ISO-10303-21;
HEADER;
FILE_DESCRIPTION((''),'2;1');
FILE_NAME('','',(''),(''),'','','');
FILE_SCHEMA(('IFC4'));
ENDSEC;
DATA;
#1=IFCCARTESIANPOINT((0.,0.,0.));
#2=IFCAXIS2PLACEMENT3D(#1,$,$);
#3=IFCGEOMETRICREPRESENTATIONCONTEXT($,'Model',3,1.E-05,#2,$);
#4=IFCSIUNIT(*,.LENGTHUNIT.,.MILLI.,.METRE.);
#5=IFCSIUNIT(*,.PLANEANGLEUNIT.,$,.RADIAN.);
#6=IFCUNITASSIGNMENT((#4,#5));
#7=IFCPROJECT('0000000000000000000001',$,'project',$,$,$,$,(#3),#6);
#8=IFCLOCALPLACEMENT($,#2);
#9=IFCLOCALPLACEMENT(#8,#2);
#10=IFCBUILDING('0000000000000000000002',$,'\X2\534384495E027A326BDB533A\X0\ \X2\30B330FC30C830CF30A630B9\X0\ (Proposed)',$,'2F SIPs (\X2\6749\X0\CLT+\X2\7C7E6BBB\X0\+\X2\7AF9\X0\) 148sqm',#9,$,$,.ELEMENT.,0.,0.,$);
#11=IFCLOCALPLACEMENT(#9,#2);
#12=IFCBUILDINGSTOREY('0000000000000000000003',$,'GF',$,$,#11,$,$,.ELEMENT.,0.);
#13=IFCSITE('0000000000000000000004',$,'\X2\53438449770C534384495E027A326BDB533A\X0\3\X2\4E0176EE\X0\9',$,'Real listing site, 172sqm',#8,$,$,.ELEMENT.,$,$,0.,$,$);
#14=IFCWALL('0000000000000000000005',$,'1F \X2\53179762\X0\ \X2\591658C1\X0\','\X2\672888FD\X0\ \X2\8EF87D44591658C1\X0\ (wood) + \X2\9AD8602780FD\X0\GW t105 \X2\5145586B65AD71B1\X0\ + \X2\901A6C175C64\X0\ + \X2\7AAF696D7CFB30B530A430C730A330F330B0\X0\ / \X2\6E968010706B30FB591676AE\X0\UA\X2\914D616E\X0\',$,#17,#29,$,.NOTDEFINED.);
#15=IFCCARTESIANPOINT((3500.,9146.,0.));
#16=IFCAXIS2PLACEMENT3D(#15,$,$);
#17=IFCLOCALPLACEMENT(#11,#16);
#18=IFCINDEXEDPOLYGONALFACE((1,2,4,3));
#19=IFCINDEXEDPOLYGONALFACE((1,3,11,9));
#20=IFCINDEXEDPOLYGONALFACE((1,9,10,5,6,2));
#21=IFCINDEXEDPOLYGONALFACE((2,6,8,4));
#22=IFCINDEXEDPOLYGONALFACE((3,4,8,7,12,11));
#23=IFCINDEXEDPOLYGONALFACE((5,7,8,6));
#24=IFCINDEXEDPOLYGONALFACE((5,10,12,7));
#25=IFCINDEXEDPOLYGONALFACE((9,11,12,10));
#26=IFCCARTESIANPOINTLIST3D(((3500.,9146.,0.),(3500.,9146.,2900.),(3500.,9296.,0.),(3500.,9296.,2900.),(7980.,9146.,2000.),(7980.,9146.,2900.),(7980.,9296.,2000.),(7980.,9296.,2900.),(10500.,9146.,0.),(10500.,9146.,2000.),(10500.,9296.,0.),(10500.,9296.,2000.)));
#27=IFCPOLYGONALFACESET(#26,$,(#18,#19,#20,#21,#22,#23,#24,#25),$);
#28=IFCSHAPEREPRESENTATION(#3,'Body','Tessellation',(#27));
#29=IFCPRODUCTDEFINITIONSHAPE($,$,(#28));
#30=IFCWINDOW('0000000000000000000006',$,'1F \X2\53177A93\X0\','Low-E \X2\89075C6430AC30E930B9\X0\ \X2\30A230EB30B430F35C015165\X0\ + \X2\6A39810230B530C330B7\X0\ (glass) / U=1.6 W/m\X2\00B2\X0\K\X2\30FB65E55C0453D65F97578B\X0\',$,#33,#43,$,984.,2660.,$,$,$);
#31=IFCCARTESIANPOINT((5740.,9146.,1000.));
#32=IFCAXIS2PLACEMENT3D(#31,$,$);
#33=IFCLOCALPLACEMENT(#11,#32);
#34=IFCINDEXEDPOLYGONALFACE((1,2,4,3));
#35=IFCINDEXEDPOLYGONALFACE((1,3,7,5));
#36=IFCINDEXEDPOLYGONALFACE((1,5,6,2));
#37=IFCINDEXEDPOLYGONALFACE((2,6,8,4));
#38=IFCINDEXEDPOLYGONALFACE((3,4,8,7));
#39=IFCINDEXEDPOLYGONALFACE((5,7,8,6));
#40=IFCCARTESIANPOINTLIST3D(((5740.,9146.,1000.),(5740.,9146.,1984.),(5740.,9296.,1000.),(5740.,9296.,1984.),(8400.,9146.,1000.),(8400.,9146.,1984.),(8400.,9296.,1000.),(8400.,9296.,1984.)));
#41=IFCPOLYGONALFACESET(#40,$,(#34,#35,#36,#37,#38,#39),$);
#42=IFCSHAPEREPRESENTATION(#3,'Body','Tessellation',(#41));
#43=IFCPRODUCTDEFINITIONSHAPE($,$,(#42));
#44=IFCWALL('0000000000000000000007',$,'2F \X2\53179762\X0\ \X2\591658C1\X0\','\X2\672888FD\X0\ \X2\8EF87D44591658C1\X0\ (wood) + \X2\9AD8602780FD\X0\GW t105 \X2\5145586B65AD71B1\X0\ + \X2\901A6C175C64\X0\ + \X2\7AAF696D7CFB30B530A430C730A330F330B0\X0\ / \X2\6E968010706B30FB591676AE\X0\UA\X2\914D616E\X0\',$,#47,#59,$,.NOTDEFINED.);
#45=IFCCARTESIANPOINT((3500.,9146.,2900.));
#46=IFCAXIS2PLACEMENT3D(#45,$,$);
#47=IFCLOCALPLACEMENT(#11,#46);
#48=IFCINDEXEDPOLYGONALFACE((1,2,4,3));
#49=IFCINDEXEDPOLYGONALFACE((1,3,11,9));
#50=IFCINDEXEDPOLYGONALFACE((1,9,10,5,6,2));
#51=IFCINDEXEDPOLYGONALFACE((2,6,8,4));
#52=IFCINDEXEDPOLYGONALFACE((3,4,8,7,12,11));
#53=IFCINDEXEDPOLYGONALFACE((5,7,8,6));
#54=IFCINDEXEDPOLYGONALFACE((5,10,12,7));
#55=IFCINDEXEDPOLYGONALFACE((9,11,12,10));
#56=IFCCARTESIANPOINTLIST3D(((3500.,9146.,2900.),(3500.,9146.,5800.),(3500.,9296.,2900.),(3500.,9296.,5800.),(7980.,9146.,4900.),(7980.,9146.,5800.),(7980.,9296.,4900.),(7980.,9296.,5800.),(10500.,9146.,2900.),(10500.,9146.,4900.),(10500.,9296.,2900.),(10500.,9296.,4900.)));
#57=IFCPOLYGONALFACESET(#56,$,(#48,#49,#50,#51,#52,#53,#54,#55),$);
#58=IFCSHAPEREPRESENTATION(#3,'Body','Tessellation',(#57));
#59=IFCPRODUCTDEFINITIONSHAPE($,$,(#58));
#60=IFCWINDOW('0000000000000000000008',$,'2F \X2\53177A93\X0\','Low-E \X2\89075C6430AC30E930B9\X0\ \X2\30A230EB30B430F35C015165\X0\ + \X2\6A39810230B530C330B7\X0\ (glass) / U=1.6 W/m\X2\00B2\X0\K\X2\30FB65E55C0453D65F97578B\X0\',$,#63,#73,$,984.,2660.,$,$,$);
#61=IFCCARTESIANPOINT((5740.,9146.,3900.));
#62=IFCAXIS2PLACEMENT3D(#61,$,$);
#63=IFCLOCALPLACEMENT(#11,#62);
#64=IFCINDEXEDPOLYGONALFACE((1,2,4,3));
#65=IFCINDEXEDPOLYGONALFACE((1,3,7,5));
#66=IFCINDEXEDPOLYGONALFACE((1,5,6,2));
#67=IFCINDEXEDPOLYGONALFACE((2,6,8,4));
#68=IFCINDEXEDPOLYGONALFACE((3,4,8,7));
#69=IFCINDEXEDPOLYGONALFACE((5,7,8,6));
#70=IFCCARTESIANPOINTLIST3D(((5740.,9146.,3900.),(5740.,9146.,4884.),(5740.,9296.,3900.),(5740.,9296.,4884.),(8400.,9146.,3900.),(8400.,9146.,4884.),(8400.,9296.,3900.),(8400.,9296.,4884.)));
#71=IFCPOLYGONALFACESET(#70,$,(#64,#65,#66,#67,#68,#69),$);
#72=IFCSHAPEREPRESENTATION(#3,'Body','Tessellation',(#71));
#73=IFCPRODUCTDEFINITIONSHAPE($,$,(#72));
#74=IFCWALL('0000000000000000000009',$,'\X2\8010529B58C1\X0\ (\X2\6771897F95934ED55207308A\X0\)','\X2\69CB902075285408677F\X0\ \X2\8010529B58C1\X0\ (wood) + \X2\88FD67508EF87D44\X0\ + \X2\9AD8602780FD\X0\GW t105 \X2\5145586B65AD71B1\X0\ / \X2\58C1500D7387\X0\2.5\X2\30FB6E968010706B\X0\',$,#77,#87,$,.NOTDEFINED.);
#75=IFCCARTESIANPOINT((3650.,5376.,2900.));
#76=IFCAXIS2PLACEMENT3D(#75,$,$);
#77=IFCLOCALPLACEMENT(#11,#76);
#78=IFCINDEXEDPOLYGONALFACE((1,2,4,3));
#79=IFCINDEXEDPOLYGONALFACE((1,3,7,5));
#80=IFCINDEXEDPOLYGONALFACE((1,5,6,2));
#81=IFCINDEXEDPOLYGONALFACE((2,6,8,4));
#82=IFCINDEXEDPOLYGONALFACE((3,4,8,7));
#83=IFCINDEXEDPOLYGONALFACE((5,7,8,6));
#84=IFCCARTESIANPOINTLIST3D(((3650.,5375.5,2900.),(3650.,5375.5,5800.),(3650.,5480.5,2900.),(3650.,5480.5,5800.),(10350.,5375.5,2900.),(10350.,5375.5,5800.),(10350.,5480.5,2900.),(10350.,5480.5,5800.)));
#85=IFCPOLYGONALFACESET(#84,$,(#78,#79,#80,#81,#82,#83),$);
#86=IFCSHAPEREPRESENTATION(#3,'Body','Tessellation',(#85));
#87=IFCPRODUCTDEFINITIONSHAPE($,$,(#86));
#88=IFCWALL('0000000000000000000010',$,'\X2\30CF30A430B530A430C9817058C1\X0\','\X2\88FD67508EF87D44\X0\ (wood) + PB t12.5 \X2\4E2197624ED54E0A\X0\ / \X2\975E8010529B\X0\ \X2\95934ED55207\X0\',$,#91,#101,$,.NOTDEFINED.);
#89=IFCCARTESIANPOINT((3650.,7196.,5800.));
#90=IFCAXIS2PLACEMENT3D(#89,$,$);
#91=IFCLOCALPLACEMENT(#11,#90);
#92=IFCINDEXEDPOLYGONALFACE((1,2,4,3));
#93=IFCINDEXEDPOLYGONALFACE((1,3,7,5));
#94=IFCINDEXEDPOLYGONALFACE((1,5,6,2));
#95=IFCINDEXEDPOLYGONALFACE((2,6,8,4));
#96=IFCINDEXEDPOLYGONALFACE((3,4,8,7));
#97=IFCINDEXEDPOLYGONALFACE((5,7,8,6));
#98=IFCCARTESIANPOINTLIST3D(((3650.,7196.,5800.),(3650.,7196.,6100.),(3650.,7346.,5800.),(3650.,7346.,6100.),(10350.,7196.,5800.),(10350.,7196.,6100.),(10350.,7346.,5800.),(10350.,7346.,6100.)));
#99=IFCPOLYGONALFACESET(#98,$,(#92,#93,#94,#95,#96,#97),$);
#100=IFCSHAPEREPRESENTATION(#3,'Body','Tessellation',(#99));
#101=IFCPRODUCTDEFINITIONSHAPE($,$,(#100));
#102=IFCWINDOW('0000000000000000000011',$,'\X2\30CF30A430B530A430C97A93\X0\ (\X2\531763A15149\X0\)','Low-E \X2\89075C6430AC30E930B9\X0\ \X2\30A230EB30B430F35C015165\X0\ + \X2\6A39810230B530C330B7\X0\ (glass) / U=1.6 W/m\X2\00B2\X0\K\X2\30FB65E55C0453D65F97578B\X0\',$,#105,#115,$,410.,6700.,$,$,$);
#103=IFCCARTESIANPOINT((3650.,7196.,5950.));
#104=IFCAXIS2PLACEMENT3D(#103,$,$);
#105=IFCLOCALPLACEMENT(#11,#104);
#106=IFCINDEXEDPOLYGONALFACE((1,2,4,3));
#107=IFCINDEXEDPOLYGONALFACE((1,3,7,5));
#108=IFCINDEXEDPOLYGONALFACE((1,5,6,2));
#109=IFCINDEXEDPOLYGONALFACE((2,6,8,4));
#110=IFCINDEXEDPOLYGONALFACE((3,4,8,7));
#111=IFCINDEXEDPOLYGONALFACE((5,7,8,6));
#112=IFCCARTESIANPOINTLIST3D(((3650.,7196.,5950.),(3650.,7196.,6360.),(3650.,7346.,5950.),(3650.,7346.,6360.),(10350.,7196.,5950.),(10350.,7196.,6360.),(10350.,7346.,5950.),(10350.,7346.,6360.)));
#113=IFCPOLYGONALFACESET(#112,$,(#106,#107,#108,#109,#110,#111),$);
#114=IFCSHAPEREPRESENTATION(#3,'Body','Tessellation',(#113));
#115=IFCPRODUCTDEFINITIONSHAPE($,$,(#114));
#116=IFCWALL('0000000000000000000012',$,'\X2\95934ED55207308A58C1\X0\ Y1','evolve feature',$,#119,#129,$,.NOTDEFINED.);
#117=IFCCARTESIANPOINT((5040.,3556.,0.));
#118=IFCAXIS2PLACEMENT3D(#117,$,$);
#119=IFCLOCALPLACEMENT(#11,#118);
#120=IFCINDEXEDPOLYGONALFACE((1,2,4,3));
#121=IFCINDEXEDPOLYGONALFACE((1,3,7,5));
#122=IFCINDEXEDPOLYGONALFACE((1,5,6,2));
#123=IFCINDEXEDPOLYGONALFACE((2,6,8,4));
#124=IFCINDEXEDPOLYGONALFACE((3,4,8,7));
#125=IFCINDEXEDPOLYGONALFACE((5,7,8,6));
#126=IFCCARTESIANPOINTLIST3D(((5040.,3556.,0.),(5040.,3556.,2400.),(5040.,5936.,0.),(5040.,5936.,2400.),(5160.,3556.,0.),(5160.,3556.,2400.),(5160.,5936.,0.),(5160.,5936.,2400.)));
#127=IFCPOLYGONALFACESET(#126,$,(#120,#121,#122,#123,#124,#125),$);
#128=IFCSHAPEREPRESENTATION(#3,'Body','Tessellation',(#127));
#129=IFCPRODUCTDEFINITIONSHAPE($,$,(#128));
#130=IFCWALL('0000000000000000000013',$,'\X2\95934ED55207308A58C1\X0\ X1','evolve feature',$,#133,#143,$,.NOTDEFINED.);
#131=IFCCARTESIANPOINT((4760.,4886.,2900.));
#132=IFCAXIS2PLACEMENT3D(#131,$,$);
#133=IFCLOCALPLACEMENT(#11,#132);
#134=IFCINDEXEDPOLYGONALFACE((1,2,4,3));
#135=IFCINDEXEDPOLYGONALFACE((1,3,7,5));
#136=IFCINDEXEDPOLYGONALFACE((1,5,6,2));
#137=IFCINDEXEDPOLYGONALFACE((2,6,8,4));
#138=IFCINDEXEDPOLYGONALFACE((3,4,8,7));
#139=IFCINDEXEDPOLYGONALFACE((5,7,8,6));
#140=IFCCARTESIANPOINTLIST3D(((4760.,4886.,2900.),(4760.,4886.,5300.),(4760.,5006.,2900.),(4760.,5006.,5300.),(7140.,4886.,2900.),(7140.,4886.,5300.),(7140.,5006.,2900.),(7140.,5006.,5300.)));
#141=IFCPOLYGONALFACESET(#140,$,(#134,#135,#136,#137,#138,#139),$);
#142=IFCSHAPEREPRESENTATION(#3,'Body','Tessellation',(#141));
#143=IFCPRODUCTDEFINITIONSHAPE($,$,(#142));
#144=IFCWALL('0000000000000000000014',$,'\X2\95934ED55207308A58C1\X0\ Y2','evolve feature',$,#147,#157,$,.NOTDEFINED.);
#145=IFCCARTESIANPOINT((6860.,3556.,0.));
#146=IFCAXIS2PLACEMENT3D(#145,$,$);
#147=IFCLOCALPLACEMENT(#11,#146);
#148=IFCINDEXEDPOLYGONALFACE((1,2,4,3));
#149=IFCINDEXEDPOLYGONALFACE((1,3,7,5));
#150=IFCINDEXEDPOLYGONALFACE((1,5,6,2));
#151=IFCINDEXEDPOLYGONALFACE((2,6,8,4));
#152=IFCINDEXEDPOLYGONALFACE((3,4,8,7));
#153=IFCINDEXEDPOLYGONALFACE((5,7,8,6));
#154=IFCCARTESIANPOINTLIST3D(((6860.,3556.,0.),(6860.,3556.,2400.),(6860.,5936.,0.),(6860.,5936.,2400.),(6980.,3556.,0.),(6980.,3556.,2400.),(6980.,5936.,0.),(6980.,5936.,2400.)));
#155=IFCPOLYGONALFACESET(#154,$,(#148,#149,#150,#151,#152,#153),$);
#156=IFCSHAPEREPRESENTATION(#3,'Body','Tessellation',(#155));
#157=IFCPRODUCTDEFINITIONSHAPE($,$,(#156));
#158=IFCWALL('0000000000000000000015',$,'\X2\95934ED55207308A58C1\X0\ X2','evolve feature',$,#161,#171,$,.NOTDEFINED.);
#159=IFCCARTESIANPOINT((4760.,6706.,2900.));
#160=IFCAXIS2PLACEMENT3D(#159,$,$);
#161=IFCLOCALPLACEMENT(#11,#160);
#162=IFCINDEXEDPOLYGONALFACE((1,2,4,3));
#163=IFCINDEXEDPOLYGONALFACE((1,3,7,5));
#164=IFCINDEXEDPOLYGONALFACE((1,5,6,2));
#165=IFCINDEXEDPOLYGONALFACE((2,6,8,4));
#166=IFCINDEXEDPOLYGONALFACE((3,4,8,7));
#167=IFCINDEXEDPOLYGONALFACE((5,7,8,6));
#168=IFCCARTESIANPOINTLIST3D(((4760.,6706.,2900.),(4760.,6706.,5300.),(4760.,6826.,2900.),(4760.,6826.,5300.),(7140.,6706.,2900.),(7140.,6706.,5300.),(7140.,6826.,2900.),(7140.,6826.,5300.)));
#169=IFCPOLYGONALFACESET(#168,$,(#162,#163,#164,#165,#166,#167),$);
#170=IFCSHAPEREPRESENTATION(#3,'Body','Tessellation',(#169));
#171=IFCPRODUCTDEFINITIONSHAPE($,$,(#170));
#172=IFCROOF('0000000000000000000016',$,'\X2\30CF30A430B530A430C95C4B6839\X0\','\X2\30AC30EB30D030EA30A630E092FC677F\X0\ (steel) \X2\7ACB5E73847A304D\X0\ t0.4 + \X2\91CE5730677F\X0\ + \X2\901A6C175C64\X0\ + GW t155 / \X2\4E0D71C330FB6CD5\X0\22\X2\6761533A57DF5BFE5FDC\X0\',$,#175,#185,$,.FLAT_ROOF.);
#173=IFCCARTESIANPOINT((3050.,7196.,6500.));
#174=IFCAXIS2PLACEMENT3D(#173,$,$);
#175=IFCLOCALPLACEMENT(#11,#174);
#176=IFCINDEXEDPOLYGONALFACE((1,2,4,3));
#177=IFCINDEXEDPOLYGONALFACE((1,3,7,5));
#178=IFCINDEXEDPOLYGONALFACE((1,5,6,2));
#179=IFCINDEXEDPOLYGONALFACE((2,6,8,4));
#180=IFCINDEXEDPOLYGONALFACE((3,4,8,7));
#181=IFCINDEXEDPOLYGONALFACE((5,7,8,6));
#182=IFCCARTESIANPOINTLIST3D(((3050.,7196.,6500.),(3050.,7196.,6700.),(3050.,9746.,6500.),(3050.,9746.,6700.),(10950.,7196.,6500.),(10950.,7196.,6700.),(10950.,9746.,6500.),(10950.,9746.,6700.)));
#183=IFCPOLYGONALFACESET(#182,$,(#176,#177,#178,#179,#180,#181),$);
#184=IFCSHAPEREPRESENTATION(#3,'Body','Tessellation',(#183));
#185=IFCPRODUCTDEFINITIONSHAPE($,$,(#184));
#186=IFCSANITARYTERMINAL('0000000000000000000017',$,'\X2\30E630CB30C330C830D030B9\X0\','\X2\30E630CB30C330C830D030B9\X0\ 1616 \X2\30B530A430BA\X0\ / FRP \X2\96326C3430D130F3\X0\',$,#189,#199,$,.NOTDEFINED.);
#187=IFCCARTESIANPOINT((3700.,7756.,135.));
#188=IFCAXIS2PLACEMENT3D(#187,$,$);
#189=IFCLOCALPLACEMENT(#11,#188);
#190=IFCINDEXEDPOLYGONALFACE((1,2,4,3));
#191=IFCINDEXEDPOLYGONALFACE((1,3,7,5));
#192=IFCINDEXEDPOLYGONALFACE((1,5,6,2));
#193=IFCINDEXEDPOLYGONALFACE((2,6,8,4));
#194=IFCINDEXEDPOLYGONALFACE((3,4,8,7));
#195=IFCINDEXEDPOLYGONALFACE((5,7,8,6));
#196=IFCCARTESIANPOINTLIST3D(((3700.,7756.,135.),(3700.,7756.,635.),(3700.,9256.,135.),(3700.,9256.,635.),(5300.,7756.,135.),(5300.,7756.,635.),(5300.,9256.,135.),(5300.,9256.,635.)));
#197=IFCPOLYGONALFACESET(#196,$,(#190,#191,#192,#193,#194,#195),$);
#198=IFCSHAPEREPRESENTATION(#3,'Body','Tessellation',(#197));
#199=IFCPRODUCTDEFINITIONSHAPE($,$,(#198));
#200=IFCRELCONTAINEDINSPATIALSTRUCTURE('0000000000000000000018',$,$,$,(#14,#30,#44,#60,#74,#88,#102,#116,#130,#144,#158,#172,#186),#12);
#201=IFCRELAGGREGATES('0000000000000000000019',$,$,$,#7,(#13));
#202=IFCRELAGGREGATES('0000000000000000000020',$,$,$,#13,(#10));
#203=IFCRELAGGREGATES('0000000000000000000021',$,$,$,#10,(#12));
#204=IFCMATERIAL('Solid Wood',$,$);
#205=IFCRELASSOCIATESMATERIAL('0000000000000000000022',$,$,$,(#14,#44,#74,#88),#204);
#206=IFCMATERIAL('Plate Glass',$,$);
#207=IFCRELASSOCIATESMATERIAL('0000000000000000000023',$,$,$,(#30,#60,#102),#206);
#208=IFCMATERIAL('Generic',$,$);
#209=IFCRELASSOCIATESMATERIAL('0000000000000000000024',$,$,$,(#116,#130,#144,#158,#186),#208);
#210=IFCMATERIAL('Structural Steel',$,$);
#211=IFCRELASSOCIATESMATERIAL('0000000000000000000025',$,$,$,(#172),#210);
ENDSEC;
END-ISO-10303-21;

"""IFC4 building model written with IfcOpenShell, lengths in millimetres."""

from ifc_helpers import new_model, si_unit, frame, frame_2d, origin, place, context, project, spatial, rectangle, extrude, material, element, fill, save


model = new_model("IFC4")

# Units and contexts
model_context = context("Model", 3, precision=1e-05, world=origin())
ifc_project = project(units=[si_unit("LENGTHUNIT", "METRE", prefix="MILLI"), si_unit("PLANEANGLEUNIT", "RADIAN")], contexts=[model_context])

# Site, building, storey
site_placement = place(None, origin())
site = spatial("IfcSite", under=ifc_project, at=site_placement, Name="千葉県千葉市稲毛区3丁目9", ObjectType="Real listing site, 172sqm", CompositionType="ELEMENT", RefElevation=0.0)
building_placement = place(site_placement, origin())
building = spatial("IfcBuilding", under=site, at=building_placement, Name="千葉市稲毛区 コートハウス (Proposed)", ObjectType="2F SIPs (杉CLT+籾殻+竹) 148sqm", CompositionType="ELEMENT", ElevationOfRefHeight=0.0, ElevationOfTerrain=0.0)
storey_placement = place(building_placement, origin())
storey = spatial("IfcBuildingStorey", under=building, at=storey_placement, Name="GF", CompositionType="ELEMENT", Elevation=0.0)

# Wall, opening, window
ifc_material_1 = material(Name="Solid Wood")
wall_1_placement = place(storey_placement, frame((3500.0, 9146.0, 0.0)))
wall_1 = element("IfcWall", 1, at=wall_1_placement, inside=storey, material=ifc_material_1, Name="1F 北面 外壁", Description="木製 軸組外壁 (wood) + 高性能GW t105 充填断熱 + 通気層 + 窯業系サイディング / 準耐火・外皮UA配慮", PredefinedType="NOTDEFINED", context=model_context, shape_type="SweptSolid", body=[
    extrude(rectangle(XDim=7000.0, YDim=150.0, at=frame_2d((3500.0, 75.0))), frame((3500.0, 9146.0, 0.0)), (0.0, 0.0, 1.0), 2900.0),
])
opening_1_placement = place(storey_placement, frame((5740.0, 9146.0, 1000.0)))
opening_1 = element("IfcOpeningElement", 2, at=opening_1_placement, cuts=wall_1, PredefinedType="NOTDEFINED", context=model_context, shape_type="SweptSolid", body=[
    extrude(rectangle(XDim=2660.0, YDim=150.0, at=frame_2d((1330.0, 75.0))), frame((5740.0, 9146.0, 1000.0)), (0.0, 0.0, 1.0), 984.0),
])
ifc_material_2 = material(Name="Plate Glass")
window_1_placement = place(storey_placement, frame((5740.0, 9146.0, 1000.0)))
window_1 = element("IfcWindow", 3, at=window_1_placement, inside=storey, material=ifc_material_2, Name="1F 北窓", Description="Low-E 複層ガラス アルゴン封入 + 樹脂サッシ (glass) / U=1.6 W/m²K・日射取得型", OverallHeight=984.0, OverallWidth=2660.0, context=model_context, shape_type="SweptSolid", body=[
    extrude(rectangle(XDim=2660.0, YDim=150.0, at=frame_2d((1330.0, 75.0))), frame((5740.0, 9146.0, 1000.0)), (0.0, 0.0, 1.0), 984.0),
])
fill(opening_1, window_1)

# Wall, opening, window
wall_2_placement = place(storey_placement, frame((3500.0, 9146.0, 2900.0)))
wall_2 = element("IfcWall", 4, at=wall_2_placement, inside=storey, material=ifc_material_1, Name="2F 北面 外壁", Description="木製 軸組外壁 (wood) + 高性能GW t105 充填断熱 + 通気層 + 窯業系サイディング / 準耐火・外皮UA配慮", PredefinedType="NOTDEFINED", context=model_context, shape_type="SweptSolid", body=[
    extrude(rectangle(XDim=7000.0, YDim=150.0, at=frame_2d((3500.0, 75.0))), frame((3500.0, 9146.0, 2900.0)), (0.0, 0.0, 1.0), 2900.0),
])
opening_2_placement = place(storey_placement, frame((5740.0, 9146.0, 3900.0)))
opening_2 = element("IfcOpeningElement", 5, at=opening_2_placement, cuts=wall_2, PredefinedType="NOTDEFINED", context=model_context, shape_type="SweptSolid", body=[
    extrude(rectangle(XDim=2660.0, YDim=150.0, at=frame_2d((1330.0, 75.0))), frame((5740.0, 9146.0, 3900.0)), (0.0, 0.0, 1.0), 984.0),
])
window_2_placement = place(storey_placement, frame((5740.0, 9146.0, 3900.0)))
window_2 = element("IfcWindow", 6, at=window_2_placement, inside=storey, material=ifc_material_2, Name="2F 北窓", Description="Low-E 複層ガラス アルゴン封入 + 樹脂サッシ (glass) / U=1.6 W/m²K・日射取得型", OverallHeight=984.0, OverallWidth=2660.0, context=model_context, shape_type="SweptSolid", body=[
    extrude(rectangle(XDim=2660.0, YDim=150.0, at=frame_2d((1330.0, 75.0))), frame((5740.0, 9146.0, 3900.0)), (0.0, 0.0, 1.0), 984.0),
])
fill(opening_2, window_2)

# Wall
wall_3_placement = place(storey_placement, frame((3650.0, 5376.0, 2900.0)))
element("IfcWall", 7, at=wall_3_placement, inside=storey, material=ifc_material_1, Name="耐力壁 (東西間仕切り)", Description="構造用合板 耐力壁 (wood) + 製材軸組 + 高性能GW t105 充填断熱 / 壁倍率2.5・準耐火", PredefinedType="NOTDEFINED", context=model_context, shape_type="SweptSolid", body=[
    extrude(rectangle(XDim=6700.0, YDim=105.0, at=frame_2d((3350.0, 52.0))), frame((3650.0, 5376.0, 2900.0)), (0.0, 0.0, 1.0), 2900.0),
])

# Wall, opening, window
wall_4_placement = place(storey_placement, frame((3650.0, 7196.0, 5800.0)))
wall_4 = element("IfcWall", 8, at=wall_4_placement, inside=storey, material=ifc_material_1, Name="ハイサイド腰壁", Description="製材軸組 (wood) + PB t12.5 両面仕上 / 非耐力 間仕切", PredefinedType="NOTDEFINED", context=model_context, shape_type="SweptSolid", body=[
    extrude(rectangle(XDim=6700.0, YDim=150.0, at=frame_2d((3350.0, 75.0))), frame((3650.0, 7196.0, 5800.0)), (0.0, 0.0, 1.0), 700.0),
])
opening_3_placement = place(storey_placement, frame((3650.0, 7196.0, 5950.0)))
opening_3 = element("IfcOpeningElement", 9, at=opening_3_placement, cuts=wall_4, PredefinedType="NOTDEFINED", context=model_context, shape_type="SweptSolid", body=[
    extrude(rectangle(XDim=6700.0, YDim=150.0, at=frame_2d((3350.0, 75.0))), frame((3650.0, 7196.0, 5950.0)), (0.0, 0.0, 1.0), 410.0),
])
window_3_placement = place(storey_placement, frame((3650.0, 7196.0, 5950.0)))
window_3 = element("IfcWindow", 10, at=window_3_placement, inside=storey, material=ifc_material_2, Name="ハイサイド窓 (北採光)", Description="Low-E 複層ガラス アルゴン封入 + 樹脂サッシ (glass) / U=1.6 W/m²K・日射取得型", OverallHeight=410.0, OverallWidth=6700.0, context=model_context, shape_type="SweptSolid", body=[
    extrude(rectangle(XDim=6700.0, YDim=150.0, at=frame_2d((3350.0, 75.0))), frame((3650.0, 7196.0, 5950.0)), (0.0, 0.0, 1.0), 410.0),
])
fill(opening_3, window_3)

# Walls
ifc_material_3 = material(Name="Generic")
wall_5_placement = place(storey_placement, frame((5040.0, 3556.0, 0.0)))
element("IfcWall", 11, at=wall_5_placement, inside=storey, material=ifc_material_3, Name="間仕切り壁 Y1", Description="evolve feature", PredefinedType="NOTDEFINED", context=model_context, shape_type="SweptSolid", body=[
    extrude(rectangle(XDim=120.0, YDim=2380.0, at=frame_2d((60.0, 1190.0))), frame((5040.0, 3556.0, 0.0)), (0.0, 0.0, 1.0), 2400.0),
])
wall_6_placement = place(storey_placement, frame((4760.0, 4886.0, 2900.0)))
element("IfcWall", 12, at=wall_6_placement, inside=storey, material=ifc_material_3, Name="間仕切り壁 X1", Description="evolve feature", PredefinedType="NOTDEFINED", context=model_context, shape_type="SweptSolid", body=[
    extrude(rectangle(XDim=2380.0, YDim=120.0, at=frame_2d((1190.0, 60.0))), frame((4760.0, 4886.0, 2900.0)), (0.0, 0.0, 1.0), 2400.0),
])
wall_7_placement = place(storey_placement, frame((6860.0, 3556.0, 0.0)))
element("IfcWall", 13, at=wall_7_placement, inside=storey, material=ifc_material_3, Name="間仕切り壁 Y2", Description="evolve feature", PredefinedType="NOTDEFINED", context=model_context, shape_type="SweptSolid", body=[
    extrude(rectangle(XDim=120.0, YDim=2380.0, at=frame_2d((60.0, 1190.0))), frame((6860.0, 3556.0, 0.0)), (0.0, 0.0, 1.0), 2400.0),
])
wall_8_placement = place(storey_placement, frame((4760.0, 6706.0, 2900.0)))
element("IfcWall", 14, at=wall_8_placement, inside=storey, material=ifc_material_3, Name="間仕切り壁 X2", Description="evolve feature", PredefinedType="NOTDEFINED", context=model_context, shape_type="SweptSolid", body=[
    extrude(rectangle(XDim=2380.0, YDim=120.0, at=frame_2d((1190.0, 60.0))), frame((4760.0, 6706.0, 2900.0)), (0.0, 0.0, 1.0), 2400.0),
])

# Roof
ifc_material_4 = material(Name="Structural Steel")
roof_placement = place(storey_placement, frame((3050.0, 7196.0, 6500.0)))
element("IfcRoof", 15, at=roof_placement, inside=storey, material=ifc_material_4, Name="ハイサイド屋根", Description="ガルバリウム鋼板 (steel) 立平葺き t0.4 + 野地板 + 通気層 + GW t155 / 不燃・法22条区域対応", PredefinedType="FLAT_ROOF", context=model_context, shape_type="SweptSolid", body=[
    extrude(rectangle(XDim=7900.0, YDim=2550.0, at=frame_2d((3950.0, 1275.0))), frame((3050.0, 7196.0, 6500.0)), (0.0, 0.0, 1.0), 200.0),
])

# Sanitary terminal
sanitary_terminal_1_placement = place(storey_placement, frame((3700.0, 7756.0, 135.0)))
element("IfcSanitaryTerminal", 16, at=sanitary_terminal_1_placement, inside=storey, material=ifc_material_3, Name="ユニットバス", Description="ユニットバス 1616 サイズ / FRP 防水パン", PredefinedType="NOTDEFINED", context=model_context, shape_type="SweptSolid", body=[
    extrude(rectangle(XDim=1600.0, YDim=1500.0, at=frame_2d((800.0, 750.0))), frame((3700.0, 7756.0, 135.0)), (0.0, 0.0, 1.0), 500.0),
])

save(model, "model.ifc")
